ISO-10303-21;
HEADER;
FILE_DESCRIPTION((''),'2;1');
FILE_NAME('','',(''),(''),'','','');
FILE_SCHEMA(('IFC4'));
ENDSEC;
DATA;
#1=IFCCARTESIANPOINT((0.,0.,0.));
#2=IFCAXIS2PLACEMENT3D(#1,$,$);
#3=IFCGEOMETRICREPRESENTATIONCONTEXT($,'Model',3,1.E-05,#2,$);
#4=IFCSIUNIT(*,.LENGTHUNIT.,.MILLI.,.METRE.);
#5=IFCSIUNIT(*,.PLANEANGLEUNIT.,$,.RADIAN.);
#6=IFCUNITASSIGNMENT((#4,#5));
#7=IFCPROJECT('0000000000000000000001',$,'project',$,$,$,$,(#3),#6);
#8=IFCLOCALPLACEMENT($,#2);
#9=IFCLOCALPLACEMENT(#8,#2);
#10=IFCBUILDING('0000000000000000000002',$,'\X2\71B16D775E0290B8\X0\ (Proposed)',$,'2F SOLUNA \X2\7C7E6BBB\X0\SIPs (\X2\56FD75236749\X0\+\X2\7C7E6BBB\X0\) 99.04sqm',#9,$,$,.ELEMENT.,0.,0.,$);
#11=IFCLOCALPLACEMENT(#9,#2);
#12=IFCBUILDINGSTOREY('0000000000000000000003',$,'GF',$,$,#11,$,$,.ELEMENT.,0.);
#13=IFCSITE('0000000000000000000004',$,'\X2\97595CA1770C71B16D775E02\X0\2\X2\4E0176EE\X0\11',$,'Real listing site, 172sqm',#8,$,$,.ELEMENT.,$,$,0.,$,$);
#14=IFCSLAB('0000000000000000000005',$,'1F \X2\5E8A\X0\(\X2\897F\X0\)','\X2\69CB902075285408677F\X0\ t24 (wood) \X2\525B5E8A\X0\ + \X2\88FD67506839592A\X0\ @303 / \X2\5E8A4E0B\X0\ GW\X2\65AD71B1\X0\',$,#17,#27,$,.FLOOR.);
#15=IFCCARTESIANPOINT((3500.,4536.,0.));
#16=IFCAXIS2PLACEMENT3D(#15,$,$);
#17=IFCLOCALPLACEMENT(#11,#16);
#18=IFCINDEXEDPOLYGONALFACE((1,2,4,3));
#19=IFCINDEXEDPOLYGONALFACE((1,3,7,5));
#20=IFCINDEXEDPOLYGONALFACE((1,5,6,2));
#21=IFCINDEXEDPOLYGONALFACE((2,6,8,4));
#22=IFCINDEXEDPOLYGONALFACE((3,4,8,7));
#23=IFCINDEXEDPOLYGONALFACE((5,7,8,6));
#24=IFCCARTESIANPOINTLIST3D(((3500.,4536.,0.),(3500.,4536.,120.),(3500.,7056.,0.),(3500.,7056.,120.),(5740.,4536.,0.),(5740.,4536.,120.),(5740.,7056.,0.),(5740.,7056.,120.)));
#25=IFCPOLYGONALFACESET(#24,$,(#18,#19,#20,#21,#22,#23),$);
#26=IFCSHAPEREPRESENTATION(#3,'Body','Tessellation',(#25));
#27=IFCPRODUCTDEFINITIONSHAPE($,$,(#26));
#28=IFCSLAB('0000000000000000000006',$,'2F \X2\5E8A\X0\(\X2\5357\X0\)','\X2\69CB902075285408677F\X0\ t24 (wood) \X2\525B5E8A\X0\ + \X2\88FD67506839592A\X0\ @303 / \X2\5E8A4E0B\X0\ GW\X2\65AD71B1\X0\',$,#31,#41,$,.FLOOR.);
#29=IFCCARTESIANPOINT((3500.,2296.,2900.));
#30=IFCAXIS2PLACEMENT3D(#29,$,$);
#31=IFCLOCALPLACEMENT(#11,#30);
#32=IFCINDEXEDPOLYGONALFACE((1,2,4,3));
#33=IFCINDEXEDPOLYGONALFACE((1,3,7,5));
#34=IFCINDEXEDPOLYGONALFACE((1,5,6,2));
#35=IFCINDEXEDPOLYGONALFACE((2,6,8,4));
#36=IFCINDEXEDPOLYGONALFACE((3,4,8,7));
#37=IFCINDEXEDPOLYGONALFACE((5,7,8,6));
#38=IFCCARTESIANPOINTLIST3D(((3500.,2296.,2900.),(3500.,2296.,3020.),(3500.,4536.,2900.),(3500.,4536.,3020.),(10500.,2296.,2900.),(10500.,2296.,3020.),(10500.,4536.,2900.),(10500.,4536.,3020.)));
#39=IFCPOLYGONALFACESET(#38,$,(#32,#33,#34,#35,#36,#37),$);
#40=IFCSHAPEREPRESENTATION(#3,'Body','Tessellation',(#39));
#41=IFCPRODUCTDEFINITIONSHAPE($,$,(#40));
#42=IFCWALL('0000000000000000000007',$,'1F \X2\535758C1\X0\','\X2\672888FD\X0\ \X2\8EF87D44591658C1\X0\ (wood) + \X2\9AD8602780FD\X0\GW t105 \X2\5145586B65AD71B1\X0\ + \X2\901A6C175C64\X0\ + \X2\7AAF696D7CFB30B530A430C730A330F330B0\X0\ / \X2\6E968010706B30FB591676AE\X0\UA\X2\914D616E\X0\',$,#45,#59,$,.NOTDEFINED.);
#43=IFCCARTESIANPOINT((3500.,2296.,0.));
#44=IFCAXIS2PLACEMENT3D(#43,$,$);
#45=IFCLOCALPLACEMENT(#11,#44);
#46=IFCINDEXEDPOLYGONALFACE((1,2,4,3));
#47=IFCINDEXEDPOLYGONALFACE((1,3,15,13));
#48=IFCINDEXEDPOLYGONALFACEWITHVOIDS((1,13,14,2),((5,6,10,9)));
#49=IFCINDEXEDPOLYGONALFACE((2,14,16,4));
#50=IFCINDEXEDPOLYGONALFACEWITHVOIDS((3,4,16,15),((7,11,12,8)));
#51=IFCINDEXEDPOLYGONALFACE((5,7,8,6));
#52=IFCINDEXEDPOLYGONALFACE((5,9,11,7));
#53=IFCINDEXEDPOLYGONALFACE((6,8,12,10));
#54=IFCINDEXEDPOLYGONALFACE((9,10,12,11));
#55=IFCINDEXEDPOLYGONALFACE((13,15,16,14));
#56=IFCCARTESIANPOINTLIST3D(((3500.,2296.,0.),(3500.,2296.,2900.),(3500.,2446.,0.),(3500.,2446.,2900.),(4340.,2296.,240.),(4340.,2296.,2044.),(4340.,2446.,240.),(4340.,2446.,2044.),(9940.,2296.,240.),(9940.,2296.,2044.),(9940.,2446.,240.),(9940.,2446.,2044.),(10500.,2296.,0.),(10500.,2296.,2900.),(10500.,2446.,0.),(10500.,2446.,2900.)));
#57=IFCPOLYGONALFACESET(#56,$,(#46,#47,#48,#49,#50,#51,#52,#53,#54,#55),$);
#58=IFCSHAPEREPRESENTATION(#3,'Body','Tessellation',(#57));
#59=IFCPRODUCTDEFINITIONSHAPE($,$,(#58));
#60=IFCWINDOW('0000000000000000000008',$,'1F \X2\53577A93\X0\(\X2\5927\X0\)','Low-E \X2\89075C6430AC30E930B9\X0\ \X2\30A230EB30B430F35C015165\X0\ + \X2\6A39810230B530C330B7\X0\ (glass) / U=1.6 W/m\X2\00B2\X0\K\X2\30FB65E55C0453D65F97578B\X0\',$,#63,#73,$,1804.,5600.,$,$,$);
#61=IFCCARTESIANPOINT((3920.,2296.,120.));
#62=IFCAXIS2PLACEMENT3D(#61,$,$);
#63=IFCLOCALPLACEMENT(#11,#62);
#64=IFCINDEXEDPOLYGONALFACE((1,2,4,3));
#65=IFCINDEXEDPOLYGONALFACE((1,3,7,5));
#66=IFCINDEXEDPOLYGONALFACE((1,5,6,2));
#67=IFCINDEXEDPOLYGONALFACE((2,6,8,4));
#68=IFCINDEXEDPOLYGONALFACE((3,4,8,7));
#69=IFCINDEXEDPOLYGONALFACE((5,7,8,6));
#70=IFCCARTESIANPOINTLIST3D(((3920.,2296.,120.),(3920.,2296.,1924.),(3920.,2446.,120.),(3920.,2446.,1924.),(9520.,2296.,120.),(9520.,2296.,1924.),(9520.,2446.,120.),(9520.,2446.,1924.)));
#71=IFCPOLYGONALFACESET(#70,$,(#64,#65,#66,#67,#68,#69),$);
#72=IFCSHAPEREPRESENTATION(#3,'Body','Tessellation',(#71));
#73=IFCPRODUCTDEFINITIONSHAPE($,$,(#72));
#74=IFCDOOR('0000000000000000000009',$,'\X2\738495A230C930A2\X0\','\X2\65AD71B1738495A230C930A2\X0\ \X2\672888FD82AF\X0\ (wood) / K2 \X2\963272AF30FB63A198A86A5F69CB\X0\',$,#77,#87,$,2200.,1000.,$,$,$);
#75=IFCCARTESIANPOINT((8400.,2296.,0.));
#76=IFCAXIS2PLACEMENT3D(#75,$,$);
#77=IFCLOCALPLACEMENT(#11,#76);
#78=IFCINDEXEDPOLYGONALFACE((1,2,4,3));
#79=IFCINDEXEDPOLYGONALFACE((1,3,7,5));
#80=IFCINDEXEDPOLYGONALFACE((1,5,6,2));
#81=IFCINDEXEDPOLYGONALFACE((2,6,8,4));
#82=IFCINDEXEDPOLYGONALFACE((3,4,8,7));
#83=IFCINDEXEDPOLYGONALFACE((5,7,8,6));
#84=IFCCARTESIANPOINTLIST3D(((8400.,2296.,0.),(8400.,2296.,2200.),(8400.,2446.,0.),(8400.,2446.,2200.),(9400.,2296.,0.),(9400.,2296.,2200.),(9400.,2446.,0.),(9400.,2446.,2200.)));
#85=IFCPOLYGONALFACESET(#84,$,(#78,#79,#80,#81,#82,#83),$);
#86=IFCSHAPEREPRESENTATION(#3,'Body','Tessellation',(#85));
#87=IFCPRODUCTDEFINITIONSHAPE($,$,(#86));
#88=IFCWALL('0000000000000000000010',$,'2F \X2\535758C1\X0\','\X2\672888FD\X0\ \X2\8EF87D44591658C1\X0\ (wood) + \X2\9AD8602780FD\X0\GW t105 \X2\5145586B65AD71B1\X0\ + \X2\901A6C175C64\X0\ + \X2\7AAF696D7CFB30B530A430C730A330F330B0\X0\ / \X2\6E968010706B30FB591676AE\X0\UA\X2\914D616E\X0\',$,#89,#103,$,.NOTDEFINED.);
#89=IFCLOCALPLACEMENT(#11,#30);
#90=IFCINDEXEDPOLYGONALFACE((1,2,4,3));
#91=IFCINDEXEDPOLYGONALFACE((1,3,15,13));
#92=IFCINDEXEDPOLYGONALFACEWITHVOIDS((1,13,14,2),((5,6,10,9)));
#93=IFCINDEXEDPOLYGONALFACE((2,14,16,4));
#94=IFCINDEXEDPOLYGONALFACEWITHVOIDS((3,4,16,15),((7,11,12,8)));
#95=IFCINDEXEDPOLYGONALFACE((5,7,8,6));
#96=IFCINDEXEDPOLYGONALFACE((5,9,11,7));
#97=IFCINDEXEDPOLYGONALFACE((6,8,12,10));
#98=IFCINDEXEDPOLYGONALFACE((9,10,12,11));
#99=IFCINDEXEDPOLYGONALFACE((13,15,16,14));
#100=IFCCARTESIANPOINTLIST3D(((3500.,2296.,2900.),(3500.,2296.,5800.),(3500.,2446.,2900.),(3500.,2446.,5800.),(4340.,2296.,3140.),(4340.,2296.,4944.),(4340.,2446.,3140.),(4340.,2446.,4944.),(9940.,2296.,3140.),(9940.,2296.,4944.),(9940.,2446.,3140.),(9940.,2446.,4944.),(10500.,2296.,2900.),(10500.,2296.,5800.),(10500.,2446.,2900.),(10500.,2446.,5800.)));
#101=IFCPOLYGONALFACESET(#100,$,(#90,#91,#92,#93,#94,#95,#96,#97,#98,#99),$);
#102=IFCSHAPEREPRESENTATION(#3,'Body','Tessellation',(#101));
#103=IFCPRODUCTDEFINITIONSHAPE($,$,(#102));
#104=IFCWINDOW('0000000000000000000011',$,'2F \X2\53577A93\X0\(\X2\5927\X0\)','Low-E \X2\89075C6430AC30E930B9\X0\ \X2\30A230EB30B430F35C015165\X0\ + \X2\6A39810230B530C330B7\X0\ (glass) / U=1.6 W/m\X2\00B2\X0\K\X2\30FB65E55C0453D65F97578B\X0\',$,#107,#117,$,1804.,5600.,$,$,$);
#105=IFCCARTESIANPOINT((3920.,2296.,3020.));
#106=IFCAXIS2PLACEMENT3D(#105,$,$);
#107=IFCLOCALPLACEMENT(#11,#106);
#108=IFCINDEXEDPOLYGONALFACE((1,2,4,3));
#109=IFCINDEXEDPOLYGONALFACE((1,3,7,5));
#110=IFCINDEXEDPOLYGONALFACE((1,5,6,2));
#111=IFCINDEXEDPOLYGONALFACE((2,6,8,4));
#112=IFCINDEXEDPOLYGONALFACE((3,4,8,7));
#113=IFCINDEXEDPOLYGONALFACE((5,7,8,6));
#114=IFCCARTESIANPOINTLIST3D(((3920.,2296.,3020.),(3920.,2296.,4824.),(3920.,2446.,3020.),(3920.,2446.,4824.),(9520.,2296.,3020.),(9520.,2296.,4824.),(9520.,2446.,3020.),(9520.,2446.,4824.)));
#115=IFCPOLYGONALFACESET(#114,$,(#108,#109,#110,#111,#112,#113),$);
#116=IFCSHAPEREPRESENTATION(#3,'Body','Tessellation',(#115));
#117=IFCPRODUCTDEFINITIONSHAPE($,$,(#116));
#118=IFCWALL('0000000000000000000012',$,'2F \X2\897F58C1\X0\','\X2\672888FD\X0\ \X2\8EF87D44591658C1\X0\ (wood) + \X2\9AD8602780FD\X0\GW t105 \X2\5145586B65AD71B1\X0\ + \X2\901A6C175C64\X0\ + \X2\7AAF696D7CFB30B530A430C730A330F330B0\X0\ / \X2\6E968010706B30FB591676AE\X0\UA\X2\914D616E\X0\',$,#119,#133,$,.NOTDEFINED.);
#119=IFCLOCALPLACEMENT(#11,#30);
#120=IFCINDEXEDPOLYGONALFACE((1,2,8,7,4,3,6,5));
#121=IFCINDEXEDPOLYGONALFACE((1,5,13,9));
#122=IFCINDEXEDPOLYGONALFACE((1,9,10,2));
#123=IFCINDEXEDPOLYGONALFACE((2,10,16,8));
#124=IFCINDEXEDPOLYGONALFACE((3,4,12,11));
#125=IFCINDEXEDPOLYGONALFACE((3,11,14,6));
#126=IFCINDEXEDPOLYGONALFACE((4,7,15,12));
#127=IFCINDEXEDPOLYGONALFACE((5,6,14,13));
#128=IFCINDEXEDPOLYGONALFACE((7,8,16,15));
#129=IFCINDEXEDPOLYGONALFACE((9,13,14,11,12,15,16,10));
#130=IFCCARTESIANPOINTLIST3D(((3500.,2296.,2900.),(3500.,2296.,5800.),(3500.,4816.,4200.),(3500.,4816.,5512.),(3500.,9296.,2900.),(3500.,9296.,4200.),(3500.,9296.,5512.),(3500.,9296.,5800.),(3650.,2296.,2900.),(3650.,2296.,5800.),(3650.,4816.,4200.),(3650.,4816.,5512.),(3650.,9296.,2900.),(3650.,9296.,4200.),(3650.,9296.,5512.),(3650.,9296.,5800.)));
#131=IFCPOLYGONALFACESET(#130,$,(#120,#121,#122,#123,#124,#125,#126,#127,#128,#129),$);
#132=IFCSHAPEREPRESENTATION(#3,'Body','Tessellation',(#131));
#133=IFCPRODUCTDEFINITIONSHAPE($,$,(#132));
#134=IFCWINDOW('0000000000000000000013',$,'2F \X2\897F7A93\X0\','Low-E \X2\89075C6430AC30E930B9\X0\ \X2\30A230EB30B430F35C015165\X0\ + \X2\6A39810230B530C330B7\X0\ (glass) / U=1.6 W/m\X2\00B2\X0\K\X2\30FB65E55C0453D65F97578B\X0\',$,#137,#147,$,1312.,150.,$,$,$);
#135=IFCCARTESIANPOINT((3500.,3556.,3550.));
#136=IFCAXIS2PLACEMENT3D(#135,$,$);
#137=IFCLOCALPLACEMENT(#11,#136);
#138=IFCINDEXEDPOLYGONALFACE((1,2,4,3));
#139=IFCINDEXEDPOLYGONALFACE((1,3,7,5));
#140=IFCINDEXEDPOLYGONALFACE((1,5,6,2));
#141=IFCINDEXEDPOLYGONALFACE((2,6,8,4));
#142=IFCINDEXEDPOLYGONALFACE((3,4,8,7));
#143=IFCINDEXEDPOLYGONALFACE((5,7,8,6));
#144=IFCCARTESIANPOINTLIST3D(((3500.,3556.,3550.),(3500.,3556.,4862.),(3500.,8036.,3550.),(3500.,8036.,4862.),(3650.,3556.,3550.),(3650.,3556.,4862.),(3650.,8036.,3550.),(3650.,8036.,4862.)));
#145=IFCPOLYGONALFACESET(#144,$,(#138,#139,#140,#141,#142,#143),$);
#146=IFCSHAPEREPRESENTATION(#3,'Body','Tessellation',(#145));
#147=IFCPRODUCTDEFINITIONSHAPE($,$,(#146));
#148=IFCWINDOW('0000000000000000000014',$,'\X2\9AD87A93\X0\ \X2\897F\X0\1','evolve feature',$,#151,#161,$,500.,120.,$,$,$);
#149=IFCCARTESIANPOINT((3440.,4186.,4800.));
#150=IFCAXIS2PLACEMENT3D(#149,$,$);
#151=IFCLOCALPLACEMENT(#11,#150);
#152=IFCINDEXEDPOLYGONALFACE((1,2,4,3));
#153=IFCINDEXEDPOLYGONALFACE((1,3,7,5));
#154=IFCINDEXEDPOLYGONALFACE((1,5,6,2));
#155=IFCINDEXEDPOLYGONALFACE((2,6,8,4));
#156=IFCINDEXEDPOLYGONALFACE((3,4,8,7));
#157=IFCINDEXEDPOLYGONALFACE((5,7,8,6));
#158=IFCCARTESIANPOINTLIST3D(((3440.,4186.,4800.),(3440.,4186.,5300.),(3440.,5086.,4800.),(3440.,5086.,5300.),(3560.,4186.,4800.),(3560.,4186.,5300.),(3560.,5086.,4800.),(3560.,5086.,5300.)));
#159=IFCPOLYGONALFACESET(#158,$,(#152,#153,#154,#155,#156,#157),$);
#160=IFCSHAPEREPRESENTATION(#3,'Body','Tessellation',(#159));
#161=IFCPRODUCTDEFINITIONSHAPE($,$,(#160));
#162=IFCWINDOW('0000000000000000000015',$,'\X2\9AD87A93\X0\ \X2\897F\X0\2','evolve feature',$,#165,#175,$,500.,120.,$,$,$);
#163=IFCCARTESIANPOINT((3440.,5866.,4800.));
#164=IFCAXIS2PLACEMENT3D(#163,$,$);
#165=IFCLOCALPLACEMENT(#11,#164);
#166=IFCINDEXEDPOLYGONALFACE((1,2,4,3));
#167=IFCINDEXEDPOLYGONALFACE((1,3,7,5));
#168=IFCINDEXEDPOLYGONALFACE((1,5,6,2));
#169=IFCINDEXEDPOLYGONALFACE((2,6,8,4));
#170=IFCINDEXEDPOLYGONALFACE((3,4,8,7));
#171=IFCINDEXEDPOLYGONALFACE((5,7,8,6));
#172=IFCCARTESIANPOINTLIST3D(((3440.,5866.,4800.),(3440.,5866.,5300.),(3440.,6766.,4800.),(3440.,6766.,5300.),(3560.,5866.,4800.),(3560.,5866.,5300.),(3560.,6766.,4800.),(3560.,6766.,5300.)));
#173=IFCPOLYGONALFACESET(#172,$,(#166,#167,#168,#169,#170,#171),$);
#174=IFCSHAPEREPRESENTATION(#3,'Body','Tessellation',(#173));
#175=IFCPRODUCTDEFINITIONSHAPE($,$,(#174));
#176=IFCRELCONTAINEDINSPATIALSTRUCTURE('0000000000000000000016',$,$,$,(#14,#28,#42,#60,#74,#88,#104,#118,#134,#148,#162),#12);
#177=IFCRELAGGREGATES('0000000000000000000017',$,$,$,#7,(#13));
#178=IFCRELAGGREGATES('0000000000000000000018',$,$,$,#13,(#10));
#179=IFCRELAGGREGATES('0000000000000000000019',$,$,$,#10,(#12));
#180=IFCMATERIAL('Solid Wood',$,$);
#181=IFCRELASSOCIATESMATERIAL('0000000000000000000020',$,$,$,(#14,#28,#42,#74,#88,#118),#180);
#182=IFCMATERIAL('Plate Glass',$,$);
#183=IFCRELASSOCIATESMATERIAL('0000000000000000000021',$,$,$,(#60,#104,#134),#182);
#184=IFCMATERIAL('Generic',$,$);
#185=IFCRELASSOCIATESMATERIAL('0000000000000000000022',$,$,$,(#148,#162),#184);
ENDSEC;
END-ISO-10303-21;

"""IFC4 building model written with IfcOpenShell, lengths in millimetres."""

from ifc_helpers import new_model, si_unit, frame, frame_2d, origin, place, context, project, spatial, rectangle, extrude, material, element, fill, save


model = new_model("IFC4")

# Units and contexts
model_context = context("Model", 3, precision=1e-05, world=origin())
ifc_project = project(units=[si_unit("LENGTHUNIT", "METRE", prefix="MILLI"), si_unit("PLANEANGLEUNIT", "RADIAN")], contexts=[model_context])

# Site, building, storey
site_placement = place(None, origin())
site = spatial("IfcSite", under=ifc_project, at=site_placement, Name="静岡県熱海市2丁目11", ObjectType="Real listing site, 172sqm", CompositionType="ELEMENT", RefElevation=0.0)
building_placement = place(site_placement, origin())
building = spatial("IfcBuilding", under=site, at=building_placement, Name="熱海市邸 (Proposed)", ObjectType="2F SOLUNA 籾殻SIPs (国産杉+籾殻) 99.04sqm", CompositionType="ELEMENT", ElevationOfRefHeight=0.0, ElevationOfTerrain=0.0)
storey_placement = place(building_placement, origin())
storey = spatial("IfcBuildingStorey", under=building, at=storey_placement, Name="GF", CompositionType="ELEMENT", Elevation=0.0)

# Slabs
ifc_material_1 = material(Name="Solid Wood")
slab_1_placement = place(storey_placement, frame((3500.0, 4536.0, 0.0)))
element("IfcSlab", 1, at=slab_1_placement, inside=storey, material=ifc_material_1, Name="1F 床(西)", Description="構造用合板 t24 (wood) 剛床 + 製材根太 @303 / 床下 GW断熱", PredefinedType="FLOOR", context=model_context, shape_type="SweptSolid", body=[
    extrude(rectangle(XDim=2240.0, YDim=2520.0, at=frame_2d((1120.0, 1260.0))), frame((3500.0, 4536.0, 0.0)), (0.0, 0.0, 1.0), 120.0),
])
slab_2_placement = place(storey_placement, frame((3500.0, 2296.0, 2900.0)))
element("IfcSlab", 2, at=slab_2_placement, inside=storey, material=ifc_material_1, Name="2F 床(南)", Description="構造用合板 t24 (wood) 剛床 + 製材根太 @303 / 床下 GW断熱", PredefinedType="FLOOR", context=model_context, shape_type="SweptSolid", body=[
    extrude(rectangle(XDim=7000.0, YDim=2240.0, at=frame_2d((3500.0, 1120.0))), frame((3500.0, 2296.0, 2900.0)), (0.0, 0.0, 1.0), 120.0),
])
ifc_material_2 = material(Name="Generic")

# Wall, openings, window, door
wall_1_placement = place(storey_placement, frame((3500.0, 2296.0, 0.0)))
wall_1 = element("IfcWall", 3, at=wall_1_placement, inside=storey, material=ifc_material_1, Name="1F 南壁", Description="木製 軸組外壁 (wood) + 高性能GW t105 充填断熱 + 通気層 + 窯業系サイディング / 準耐火・外皮UA配慮", PredefinedType="NOTDEFINED", context=model_context, shape_type="SweptSolid", body=[
    extrude(rectangle(XDim=7000.0, YDim=150.0, at=frame_2d((3500.0, 75.0))), frame((3500.0, 2296.0, 0.0)), (0.0, 0.0, 1.0), 2900.0),
])
opening_1_placement = place(storey_placement, frame((3920.0, 2296.0, 120.0)))
opening_1 = element("IfcOpeningElement", 4, at=opening_1_placement, cuts=wall_1, PredefinedType="NOTDEFINED", context=model_context, shape_type="SweptSolid", body=[
    extrude(rectangle(XDim=5600.0, YDim=150.0, at=frame_2d((2800.0, 75.0))), frame((3920.0, 2296.0, 120.0)), (0.0, 0.0, 1.0), 1804.0),
])
opening_2_placement = place(storey_placement, frame((8400.0, 2296.0, 0.0)))
opening_2 = element("IfcOpeningElement", 5, at=opening_2_placement, cuts=wall_1, PredefinedType="NOTDEFINED", context=model_context, shape_type="SweptSolid", body=[
    extrude(rectangle(XDim=1000.0, YDim=150.0, at=frame_2d((500.0, 75.0))), frame((8400.0, 2296.0, 0.0)), (0.0, 0.0, 1.0), 2200.0),
])
ifc_material_3 = material(Name="Plate Glass")
window_1_placement = place(storey_placement, frame((3920.0, 2296.0, 120.0)))
window_1 = element("IfcWindow", 6, at=window_1_placement, inside=storey, material=ifc_material_3, Name="1F 南窓(大)", Description="Low-E 複層ガラス アルゴン封入 + 樹脂サッシ (glass) / U=1.6 W/m²K・日射取得型", OverallHeight=1804.0, OverallWidth=5600.0, context=model_context, shape_type="SweptSolid", body=[
    extrude(rectangle(XDim=5600.0, YDim=150.0, at=frame_2d((2800.0, 75.0))), frame((3920.0, 2296.0, 120.0)), (0.0, 0.0, 1.0), 1804.0),
])
fill(opening_1, window_1)
door_placement = place(storey_placement, frame((8400.0, 2296.0, 0.0)))
door = element("IfcDoor", 7, at=door_placement, inside=storey, material=ifc_material_1, Name="玄関ドア", Description="断熱玄関ドア 木製芯 (wood) / K2 防犯・採風機構", OverallHeight=2200.0, OverallWidth=1000.0, context=model_context, shape_type="SweptSolid", body=[
    extrude(rectangle(XDim=1000.0, YDim=150.0, at=frame_2d((500.0, 75.0))), frame((8400.0, 2296.0, 0.0)), (0.0, 0.0, 1.0), 2200.0),
])
fill(opening_2, door)

# Wall, opening, window
wall_2_placement = place(storey_placement, frame((3500.0, 2296.0, 2900.0)))
wall_2 = element("IfcWall", 8, at=wall_2_placement, inside=storey, material=ifc_material_1, Name="2F 南壁", Description="木製 軸組外壁 (wood) + 高性能GW t105 充填断熱 + 通気層 + 窯業系サイディング / 準耐火・外皮UA配慮", PredefinedType="NOTDEFINED", context=model_context, shape_type="SweptSolid", body=[
    extrude(rectangle(XDim=7000.0, YDim=150.0, at=frame_2d((3500.0, 75.0))), frame((3500.0, 2296.0, 2900.0)), (0.0, 0.0, 1.0), 2900.0),
])
opening_3_placement = place(storey_placement, frame((3920.0, 2296.0, 3020.0)))
opening_3 = element("IfcOpeningElement", 9, at=opening_3_placement, cuts=wall_2, PredefinedType="NOTDEFINED", context=model_context, shape_type="SweptSolid", body=[
    extrude(rectangle(XDim=5600.0, YDim=150.0, at=frame_2d((2800.0, 75.0))), frame((3920.0, 2296.0, 3020.0)), (0.0, 0.0, 1.0), 1804.0),
])
window_2_placement = place(storey_placement, frame((3920.0, 2296.0, 3020.0)))
window_2 = element("IfcWindow", 10, at=window_2_placement, inside=storey, material=ifc_material_3, Name="2F 南窓(大)", Description="Low-E 複層ガラス アルゴン封入 + 樹脂サッシ (glass) / U=1.6 W/m²K・日射取得型", OverallHeight=1804.0, OverallWidth=5600.0, context=model_context, shape_type="SweptSolid", body=[
    extrude(rectangle(XDim=5600.0, YDim=150.0, at=frame_2d((2800.0, 75.0))), frame((3920.0, 2296.0, 3020.0)), (0.0, 0.0, 1.0), 1804.0),
])
fill(opening_3, window_2)

# Wall, openings, windows
wall_3_placement = place(storey_placement, frame((3500.0, 2296.0, 2900.0)))
wall_3 = element("IfcWall", 11, at=wall_3_placement, inside=storey, material=ifc_material_1, Name="2F 西壁", Description="木製 軸組外壁 (wood) + 高性能GW t105 充填断熱 + 通気層 + 窯業系サイディング / 準耐火・外皮UA配慮", PredefinedType="NOTDEFINED", context=model_context, shape_type="SweptSolid", body=[
    extrude(rectangle(XDim=150.0, YDim=7000.0, at=frame_2d((75.0, 3500.0))), frame((3500.0, 2296.0, 2900.0)), (0.0, 0.0, 1.0), 2900.0),
])
opening_4_placement = place(storey_placement, frame((3500.0, 3556.0, 3550.0)))
opening_4 = element("IfcOpeningElement", 12, at=opening_4_placement, cuts=wall_3, PredefinedType="NOTDEFINED", context=model_context, shape_type="SweptSolid", body=[
    extrude(rectangle(XDim=150.0, YDim=4480.0, at=frame_2d((75.0, 2240.0))), frame((3500.0, 3556.0, 3550.0)), (0.0, 0.0, 1.0), 1312.0),
])
opening_5_placement = place(storey_placement, frame((3440.0, 4186.0, 4800.0)))
opening_5 = element("IfcOpeningElement", 13, at=opening_5_placement, cuts=wall_3, PredefinedType="NOTDEFINED", context=model_context, shape_type="SweptSolid", body=[
    extrude(rectangle(XDim=120.0, YDim=900.0, at=frame_2d((60.0, 450.0))), frame((3440.0, 4186.0, 4800.0)), (0.0, 0.0, 1.0), 500.0),
])
opening_6_placement = place(storey_placement, frame((3440.0, 5866.0, 4800.0)))
opening_6 = element("IfcOpeningElement", 14, at=opening_6_placement, cuts=wall_3, PredefinedType="NOTDEFINED", context=model_context, shape_type="SweptSolid", body=[
    extrude(rectangle(XDim=120.0, YDim=900.0, at=frame_2d((60.0, 450.0))), frame((3440.0, 5866.0, 4800.0)), (0.0, 0.0, 1.0), 500.0),
])
window_3_placement = place(storey_placement, frame((3500.0, 3556.0, 3550.0)))
window_3 = element("IfcWindow", 15, at=window_3_placement, inside=storey, material=ifc_material_3, Name="2F 西窓", Description="Low-E 複層ガラス アルゴン封入 + 樹脂サッシ (glass) / U=1.6 W/m²K・日射取得型", OverallHeight=1312.0, OverallWidth=150.0, context=model_context, shape_type="SweptSolid", body=[
    extrude(rectangle(XDim=150.0, YDim=4480.0, at=frame_2d((75.0, 2240.0))), frame((3500.0, 3556.0, 3550.0)), (0.0, 0.0, 1.0), 1312.0),
])
fill(opening_4, window_3)
window_4_placement = place(storey_placement, frame((3440.0, 4186.0, 4800.0)))
window_4 = element("IfcWindow", 16, at=window_4_placement, inside=storey, material=ifc_material_2, Name="高窓 西1", Description="evolve feature", OverallHeight=500.0, OverallWidth=120.0, context=model_context, shape_type="SweptSolid", body=[
    extrude(rectangle(XDim=120.0, YDim=900.0, at=frame_2d((60.0, 450.0))), frame((3440.0, 4186.0, 4800.0)), (0.0, 0.0, 1.0), 500.0),
])
fill(opening_5, window_4)
window_5_placement = place(storey_placement, frame((3440.0, 5866.0, 4800.0)))
window_5 = element("IfcWindow", 17, at=window_5_placement, inside=storey, material=ifc_material_2, Name="高窓 西2", Description="evolve feature", OverallHeight=500.0, OverallWidth=120.0, context=model_context, shape_type="SweptSolid", body=[
    extrude(rectangle(XDim=120.0, YDim=900.0, at=frame_2d((60.0, 450.0))), frame((3440.0, 5866.0, 4800.0)), (0.0, 0.0, 1.0), 500.0),
])
fill(opening_6, window_5)

save(model, "model.ifc")
